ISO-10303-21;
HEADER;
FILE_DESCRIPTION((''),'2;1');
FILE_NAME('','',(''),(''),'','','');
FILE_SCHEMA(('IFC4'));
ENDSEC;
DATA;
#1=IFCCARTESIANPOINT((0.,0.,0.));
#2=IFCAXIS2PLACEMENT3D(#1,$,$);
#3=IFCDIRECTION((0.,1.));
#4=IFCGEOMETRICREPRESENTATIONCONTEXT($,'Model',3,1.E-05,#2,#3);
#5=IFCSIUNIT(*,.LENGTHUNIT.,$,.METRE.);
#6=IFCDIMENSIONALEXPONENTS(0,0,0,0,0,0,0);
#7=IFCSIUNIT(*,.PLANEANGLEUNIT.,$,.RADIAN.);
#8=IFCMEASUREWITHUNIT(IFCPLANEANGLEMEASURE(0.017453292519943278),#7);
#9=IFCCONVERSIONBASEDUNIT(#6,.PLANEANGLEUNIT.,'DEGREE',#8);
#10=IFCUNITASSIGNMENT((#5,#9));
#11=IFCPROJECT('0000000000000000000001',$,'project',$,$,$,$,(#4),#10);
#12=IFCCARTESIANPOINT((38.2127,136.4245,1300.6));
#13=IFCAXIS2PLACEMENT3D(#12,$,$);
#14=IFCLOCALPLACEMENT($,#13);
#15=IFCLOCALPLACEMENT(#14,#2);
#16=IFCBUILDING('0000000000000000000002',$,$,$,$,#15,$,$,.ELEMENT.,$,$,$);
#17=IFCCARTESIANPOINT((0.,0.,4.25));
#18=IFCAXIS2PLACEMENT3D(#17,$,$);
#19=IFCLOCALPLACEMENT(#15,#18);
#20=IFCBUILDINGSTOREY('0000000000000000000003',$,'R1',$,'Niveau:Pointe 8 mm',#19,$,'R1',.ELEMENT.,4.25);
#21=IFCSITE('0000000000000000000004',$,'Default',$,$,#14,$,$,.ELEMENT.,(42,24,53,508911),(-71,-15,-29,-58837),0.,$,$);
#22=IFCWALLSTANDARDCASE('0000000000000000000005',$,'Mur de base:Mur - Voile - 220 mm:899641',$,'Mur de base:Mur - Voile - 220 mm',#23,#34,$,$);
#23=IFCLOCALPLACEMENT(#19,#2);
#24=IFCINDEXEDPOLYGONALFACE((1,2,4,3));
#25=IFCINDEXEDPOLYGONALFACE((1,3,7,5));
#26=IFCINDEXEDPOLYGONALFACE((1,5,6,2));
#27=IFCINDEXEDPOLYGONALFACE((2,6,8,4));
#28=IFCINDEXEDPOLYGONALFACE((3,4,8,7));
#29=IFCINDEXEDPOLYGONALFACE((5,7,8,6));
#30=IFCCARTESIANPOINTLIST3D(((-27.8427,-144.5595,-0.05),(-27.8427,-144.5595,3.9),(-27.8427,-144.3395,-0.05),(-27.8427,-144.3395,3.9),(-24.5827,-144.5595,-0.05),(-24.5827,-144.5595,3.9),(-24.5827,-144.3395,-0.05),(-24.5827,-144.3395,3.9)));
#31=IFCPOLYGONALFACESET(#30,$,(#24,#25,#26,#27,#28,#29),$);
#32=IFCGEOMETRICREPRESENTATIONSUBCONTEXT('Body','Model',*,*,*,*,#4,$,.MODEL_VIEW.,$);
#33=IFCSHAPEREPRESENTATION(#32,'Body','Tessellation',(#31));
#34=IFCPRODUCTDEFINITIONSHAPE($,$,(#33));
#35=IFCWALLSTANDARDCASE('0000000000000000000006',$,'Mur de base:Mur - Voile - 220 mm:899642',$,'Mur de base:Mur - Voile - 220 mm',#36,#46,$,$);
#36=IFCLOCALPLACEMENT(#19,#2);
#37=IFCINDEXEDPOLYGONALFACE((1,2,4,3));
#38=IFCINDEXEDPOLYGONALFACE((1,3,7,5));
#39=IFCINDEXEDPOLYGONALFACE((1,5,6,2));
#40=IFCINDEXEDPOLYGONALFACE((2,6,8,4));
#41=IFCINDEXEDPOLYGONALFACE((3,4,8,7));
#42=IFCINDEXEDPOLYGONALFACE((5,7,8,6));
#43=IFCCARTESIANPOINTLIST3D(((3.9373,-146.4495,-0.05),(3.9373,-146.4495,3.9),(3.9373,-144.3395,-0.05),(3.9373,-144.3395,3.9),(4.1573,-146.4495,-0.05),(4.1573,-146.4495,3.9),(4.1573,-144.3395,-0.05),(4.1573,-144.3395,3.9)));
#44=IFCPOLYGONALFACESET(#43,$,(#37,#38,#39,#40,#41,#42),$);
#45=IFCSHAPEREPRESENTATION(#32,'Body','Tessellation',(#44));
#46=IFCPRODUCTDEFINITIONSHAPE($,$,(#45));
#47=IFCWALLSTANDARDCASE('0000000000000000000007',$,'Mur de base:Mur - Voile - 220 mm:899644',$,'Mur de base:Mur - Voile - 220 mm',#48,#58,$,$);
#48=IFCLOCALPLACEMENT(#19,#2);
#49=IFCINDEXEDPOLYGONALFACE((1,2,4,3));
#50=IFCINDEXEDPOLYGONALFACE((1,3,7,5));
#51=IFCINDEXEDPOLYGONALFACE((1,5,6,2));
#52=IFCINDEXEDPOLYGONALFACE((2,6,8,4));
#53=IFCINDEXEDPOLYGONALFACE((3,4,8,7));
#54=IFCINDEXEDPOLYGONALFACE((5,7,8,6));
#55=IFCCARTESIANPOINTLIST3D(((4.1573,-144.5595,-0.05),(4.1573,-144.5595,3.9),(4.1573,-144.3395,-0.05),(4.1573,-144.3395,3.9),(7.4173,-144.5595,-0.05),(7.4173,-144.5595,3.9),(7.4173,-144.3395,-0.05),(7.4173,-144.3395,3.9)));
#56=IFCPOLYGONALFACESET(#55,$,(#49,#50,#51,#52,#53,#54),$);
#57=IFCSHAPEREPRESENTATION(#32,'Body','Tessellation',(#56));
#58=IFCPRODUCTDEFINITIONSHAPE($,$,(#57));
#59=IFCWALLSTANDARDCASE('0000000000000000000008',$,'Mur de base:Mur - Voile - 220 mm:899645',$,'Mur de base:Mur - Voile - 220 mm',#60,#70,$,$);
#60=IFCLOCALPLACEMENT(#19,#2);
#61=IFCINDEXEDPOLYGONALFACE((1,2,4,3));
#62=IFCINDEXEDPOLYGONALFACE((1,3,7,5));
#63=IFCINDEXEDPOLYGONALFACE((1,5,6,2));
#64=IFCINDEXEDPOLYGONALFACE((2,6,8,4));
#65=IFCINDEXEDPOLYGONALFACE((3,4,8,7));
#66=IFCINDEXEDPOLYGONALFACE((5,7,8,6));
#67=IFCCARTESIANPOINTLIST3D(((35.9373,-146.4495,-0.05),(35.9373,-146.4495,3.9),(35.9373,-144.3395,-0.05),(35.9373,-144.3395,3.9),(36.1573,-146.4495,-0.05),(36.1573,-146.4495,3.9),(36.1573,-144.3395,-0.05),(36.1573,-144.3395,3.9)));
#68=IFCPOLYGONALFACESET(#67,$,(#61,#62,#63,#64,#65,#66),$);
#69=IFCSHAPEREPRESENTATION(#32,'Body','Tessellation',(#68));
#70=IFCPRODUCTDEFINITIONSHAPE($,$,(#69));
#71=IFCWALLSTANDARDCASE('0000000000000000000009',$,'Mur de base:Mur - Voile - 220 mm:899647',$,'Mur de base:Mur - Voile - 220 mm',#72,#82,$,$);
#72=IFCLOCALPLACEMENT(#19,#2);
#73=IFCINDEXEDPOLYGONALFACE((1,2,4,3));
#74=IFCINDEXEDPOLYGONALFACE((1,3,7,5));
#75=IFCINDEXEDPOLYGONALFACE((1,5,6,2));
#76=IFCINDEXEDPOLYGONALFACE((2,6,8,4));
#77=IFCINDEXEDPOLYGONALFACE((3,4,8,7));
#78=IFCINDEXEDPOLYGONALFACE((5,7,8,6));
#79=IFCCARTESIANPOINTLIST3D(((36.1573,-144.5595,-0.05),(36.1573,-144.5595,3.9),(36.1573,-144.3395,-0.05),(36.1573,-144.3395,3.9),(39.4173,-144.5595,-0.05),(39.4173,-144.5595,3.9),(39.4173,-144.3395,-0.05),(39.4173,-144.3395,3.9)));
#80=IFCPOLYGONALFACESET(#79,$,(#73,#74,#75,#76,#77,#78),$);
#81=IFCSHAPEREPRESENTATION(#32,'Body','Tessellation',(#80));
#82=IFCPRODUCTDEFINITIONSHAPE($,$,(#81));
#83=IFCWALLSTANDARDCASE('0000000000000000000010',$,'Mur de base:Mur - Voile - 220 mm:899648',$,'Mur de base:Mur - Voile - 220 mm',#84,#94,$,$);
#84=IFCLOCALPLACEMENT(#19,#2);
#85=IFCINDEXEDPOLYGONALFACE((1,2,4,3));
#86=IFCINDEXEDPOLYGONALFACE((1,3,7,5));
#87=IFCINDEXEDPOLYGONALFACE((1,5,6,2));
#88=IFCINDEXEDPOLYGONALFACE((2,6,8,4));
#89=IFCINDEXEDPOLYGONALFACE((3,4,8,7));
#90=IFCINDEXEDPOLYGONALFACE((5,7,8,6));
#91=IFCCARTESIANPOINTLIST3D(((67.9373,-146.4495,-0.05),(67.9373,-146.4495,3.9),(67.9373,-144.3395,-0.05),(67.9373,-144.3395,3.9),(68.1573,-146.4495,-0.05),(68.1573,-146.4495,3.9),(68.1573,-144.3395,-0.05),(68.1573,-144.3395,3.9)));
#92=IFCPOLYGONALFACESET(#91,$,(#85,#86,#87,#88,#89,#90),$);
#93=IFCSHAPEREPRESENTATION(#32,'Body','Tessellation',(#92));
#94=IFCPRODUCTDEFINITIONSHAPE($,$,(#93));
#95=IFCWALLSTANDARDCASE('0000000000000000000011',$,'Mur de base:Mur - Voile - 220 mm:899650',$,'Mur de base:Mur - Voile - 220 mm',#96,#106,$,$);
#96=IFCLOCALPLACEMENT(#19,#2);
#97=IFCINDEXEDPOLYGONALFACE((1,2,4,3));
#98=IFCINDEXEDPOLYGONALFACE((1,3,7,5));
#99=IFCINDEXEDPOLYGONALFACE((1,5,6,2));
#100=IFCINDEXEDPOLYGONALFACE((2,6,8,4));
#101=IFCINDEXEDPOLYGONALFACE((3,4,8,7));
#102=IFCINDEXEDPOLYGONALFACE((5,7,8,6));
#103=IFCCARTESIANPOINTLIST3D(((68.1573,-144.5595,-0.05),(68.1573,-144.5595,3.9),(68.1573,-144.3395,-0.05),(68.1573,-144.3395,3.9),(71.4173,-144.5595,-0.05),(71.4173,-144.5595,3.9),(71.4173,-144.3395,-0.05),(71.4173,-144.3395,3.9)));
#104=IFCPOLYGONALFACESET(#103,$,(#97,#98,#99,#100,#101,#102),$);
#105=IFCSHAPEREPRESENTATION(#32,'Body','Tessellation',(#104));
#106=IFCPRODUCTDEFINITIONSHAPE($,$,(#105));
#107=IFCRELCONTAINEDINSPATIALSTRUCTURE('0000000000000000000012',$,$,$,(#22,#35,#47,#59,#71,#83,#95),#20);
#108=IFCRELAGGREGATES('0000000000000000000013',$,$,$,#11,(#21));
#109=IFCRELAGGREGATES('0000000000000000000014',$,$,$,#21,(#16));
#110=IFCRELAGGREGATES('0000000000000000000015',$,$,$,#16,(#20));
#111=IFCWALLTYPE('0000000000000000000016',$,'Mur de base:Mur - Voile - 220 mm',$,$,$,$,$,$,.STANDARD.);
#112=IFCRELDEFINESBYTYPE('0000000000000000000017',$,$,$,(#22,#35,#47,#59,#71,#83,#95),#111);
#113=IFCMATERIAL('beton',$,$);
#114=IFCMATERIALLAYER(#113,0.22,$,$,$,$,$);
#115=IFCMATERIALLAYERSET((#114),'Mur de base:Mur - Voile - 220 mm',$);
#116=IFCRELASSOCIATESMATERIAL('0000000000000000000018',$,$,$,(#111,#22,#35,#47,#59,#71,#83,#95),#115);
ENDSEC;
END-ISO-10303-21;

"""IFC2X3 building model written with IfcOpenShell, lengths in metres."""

from ifc_helpers import new_model, entity, si_unit, converted_unit, direction, frame, frame_2d, origin, place, context, subcontext, project, spatial, polyline, rectangle, extrude, clip, bounded_halfspace, material, layer, layer_set, layer_usage, type_object, element, save


model = new_model("IFC2X3")

# Units and contexts
model_context = context("Model", 3, precision=1e-05, world=origin(), true_north=direction((0.0, 1.0)))
body_context = subcontext(model_context, "Body", "Model", "MODEL_VIEW")
ifc_project = project(units=[si_unit("LENGTHUNIT", "METRE"), converted_unit("PLANEANGLEUNIT", "DEGREE", entity("IfcPlaneAngleMeasure", 0.017453292519943278), si_unit("PLANEANGLEUNIT", "RADIAN"), dimensions=[0, 0, 0, 0, 0, 0, 0])], contexts=[model_context])

# Site, building, storey
site_placement = place(None, frame((38.2127, 136.4245, 1300.6)))
site = spatial("IfcSite", under=ifc_project, at=site_placement, Name="Default", CompositionType="ELEMENT", RefLatitude=(42, 24, 53, 508911), RefLongitude=(-71, -15, -29, -58837), RefElevation=0.0)
building_placement = place(site_placement, origin())
building = spatial("IfcBuilding", under=site, at=building_placement, CompositionType="ELEMENT")
storey_placement = place(building_placement, frame((0.0, 0.0, 4.25)))
storey = spatial("IfcBuildingStorey", under=building, at=storey_placement, Name="R1", ObjectType="Niveau:Pointe 8 mm", LongName="R1", CompositionType="ELEMENT", Elevation=4.25)

# Walls
ifc_material_1 = material(Name="beton")
ifc_layer_1 = layer(ifc_material_1, 0.22)
ifc_layer_set_1 = layer_set([ifc_layer_1], Name="Mur de base:Mur - Voile - 220 mm")
wall_type = type_object("IfcWallType", Name="Mur de base:Mur - Voile - 220 mm", PredefinedType="STANDARD", material=ifc_layer_set_1)
ifc_layer_usage_1 = layer_usage(ifc_layer_set_1, "AXIS2", "NEGATIVE", 0.11)
wall_1_placement = place(storey_placement, frame((-24.5827, -144.4495, -0.05), z_axis=(0.0, 0.0, 1.0), x_axis=(-1.0, 0.0, 0.0)))
element("IfcWallStandardCase", 1, at=wall_1_placement, inside=storey, type_object=wall_type, material=ifc_layer_usage_1, Name="Mur de base:Mur - Voile - 220 mm:899641", ObjectType="Mur de base:Mur - Voile - 220 mm", context=body_context, shape_type="Clipping", body=[
    clip(extrude(rectangle(XDim=3.26, YDim=0.22, at=frame_2d((1.63, 0.0), x_axis=(-1.0, 0.0))), origin(), (0.0, 0.0, 1.0), 3.95), bounded_halfspace(frame((0.0, -0.11, 3.95), z_axis=(0.0, 0.0, -1.0), x_axis=(-1.0, 0.0, 0.0)), True, frame((0.0, -0.11, 3.95)), polyline([(0.0, 0.0), (3.26, 0.0), (3.26, 0.22), (3.255, 0.22), (0.0, 0.22), (0.0, 0.0)]))),
])
ifc_layer_usage_2 = layer_usage(ifc_layer_set_1, "AXIS2", "NEGATIVE", 0.11)
wall_2_placement = place(storey_placement, frame((4.0473, -144.3395, -0.05), z_axis=(0.0, 0.0, 1.0), x_axis=(0.0, -1.0, 0.0)))
element("IfcWallStandardCase", 2, at=wall_2_placement, inside=storey, type_object=wall_type, material=ifc_layer_usage_2, Name="Mur de base:Mur - Voile - 220 mm:899642", ObjectType="Mur de base:Mur - Voile - 220 mm", context=body_context, shape_type="Clipping", body=[
    clip(extrude(rectangle(XDim=2.11, YDim=0.22, at=frame_2d((1.055, 0.0), x_axis=(-1.0, 0.0))), origin(), (0.0, 0.0, 1.0), 3.95), bounded_halfspace(frame((0.0, -0.11, 3.95), z_axis=(0.0, 0.0, -1.0), x_axis=(0.0, 1.0, 0.0)), True, frame((0.0, -0.11, 3.95)), polyline([(0.0, 0.0), (1.94, 0.0), (2.11, 0.0), (2.11, 0.22), (1.94, 0.22), (0.22, 0.22), (0.0, 0.22), (0.0, 0.0)]))),
])
ifc_layer_usage_3 = layer_usage(ifc_layer_set_1, "AXIS2", "NEGATIVE", 0.11)
wall_3_placement = place(storey_placement, frame((7.4173, -144.4495, -0.05), z_axis=(0.0, 0.0, 1.0), x_axis=(-1.0, 0.0, 0.0)))
element("IfcWallStandardCase", 3, at=wall_3_placement, inside=storey, type_object=wall_type, material=ifc_layer_usage_3, Name="Mur de base:Mur - Voile - 220 mm:899644", ObjectType="Mur de base:Mur - Voile - 220 mm", context=body_context, shape_type="Clipping", body=[
    clip(extrude(rectangle(XDim=3.26, YDim=0.22, at=frame_2d((1.63, 0.0), x_axis=(-1.0, 0.0))), origin(), (0.0, 0.0, 1.0), 3.95), bounded_halfspace(frame((0.0, -0.11, 3.95), z_axis=(0.0, 0.0, -1.0), x_axis=(-1.0, 0.0, 0.0)), True, frame((0.0, -0.11, 3.95)), polyline([(0.0, 0.0), (3.26, 0.0), (3.26, 0.22), (3.255, 0.22), (0.0, 0.22), (0.0, 0.0)]))),
])
ifc_layer_usage_4 = layer_usage(ifc_layer_set_1, "AXIS2", "NEGATIVE", 0.11)
wall_4_placement = place(storey_placement, frame((36.0473, -144.3395, -0.05), z_axis=(0.0, 0.0, 1.0), x_axis=(0.0, -1.0, 0.0)))
element("IfcWallStandardCase", 4, at=wall_4_placement, inside=storey, type_object=wall_type, material=ifc_layer_usage_4, Name="Mur de base:Mur - Voile - 220 mm:899645", ObjectType="Mur de base:Mur - Voile - 220 mm", context=body_context, shape_type="Clipping", body=[
    clip(extrude(rectangle(XDim=2.11, YDim=0.22, at=frame_2d((1.055, 0.0), x_axis=(-1.0, 0.0))), origin(), (0.0, 0.0, 1.0), 3.95), bounded_halfspace(frame((0.0, -0.11, 3.95), z_axis=(0.0, 0.0, -1.0), x_axis=(0.0, 1.0, 0.0)), True, frame((0.0, -0.11, 3.95)), polyline([(0.0, 0.0), (1.94, 0.0), (2.11, 0.0), (2.11, 0.22), (1.94, 0.22), (0.22, 0.22), (0.0, 0.22), (0.0, 0.0)]))),
])
ifc_layer_usage_5 = layer_usage(ifc_layer_set_1, "AXIS2", "NEGATIVE", 0.11)
wall_5_placement = place(storey_placement, frame((39.4173, -144.4495, -0.05), z_axis=(0.0, 0.0, 1.0), x_axis=(-1.0, 0.0, 0.0)))
element("IfcWallStandardCase", 5, at=wall_5_placement, inside=storey, type_object=wall_type, material=ifc_layer_usage_5, Name="Mur de base:Mur - Voile - 220 mm:899647", ObjectType="Mur de base:Mur - Voile - 220 mm", context=body_context, shape_type="Clipping", body=[
    clip(extrude(rectangle(XDim=3.26, YDim=0.22, at=frame_2d((1.63, 0.0), x_axis=(-1.0, 0.0))), origin(), (0.0, 0.0, 1.0), 3.95), bounded_halfspace(frame((0.0, -0.11, 3.95), z_axis=(0.0, 0.0, -1.0), x_axis=(-1.0, 0.0, 0.0)), True, frame((0.0, -0.11, 3.95)), polyline([(0.0, 0.0), (3.26, 0.0), (3.26, 0.22), (3.255, 0.22), (0.0, 0.22), (0.0, 0.0)]))),
])
ifc_layer_usage_6 = layer_usage(ifc_layer_set_1, "AXIS2", "NEGATIVE", 0.11)
wall_6_placement = place(storey_placement, frame((68.0473, -144.3395, -0.05), z_axis=(0.0, 0.0, 1.0), x_axis=(0.0, -1.0, 0.0)))
element("IfcWallStandardCase", 6, at=wall_6_placement, inside=storey, type_object=wall_type, material=ifc_layer_usage_6, Name="Mur de base:Mur - Voile - 220 mm:899648", ObjectType="Mur de base:Mur - Voile - 220 mm", context=body_context, shape_type="Clipping", body=[
    clip(extrude(rectangle(XDim=2.11, YDim=0.22, at=frame_2d((1.055, 0.0), x_axis=(-1.0, 0.0))), origin(), (0.0, 0.0, 1.0), 3.95), bounded_halfspace(frame((0.0, -0.11, 3.95), z_axis=(0.0, 0.0, -1.0), x_axis=(0.0, 1.0, 0.0)), True, frame((0.0, -0.11, 3.95)), polyline([(0.0, 0.0), (1.94, 0.0), (2.11, 0.0), (2.11, 0.22), (1.94, 0.22), (0.22, 0.22), (0.0, 0.22), (0.0, 0.0)]))),
])
ifc_layer_usage_7 = layer_usage(ifc_layer_set_1, "AXIS2", "NEGATIVE", 0.11)
wall_7_placement = place(storey_placement, frame((71.4173, -144.4495, -0.05), z_axis=(0.0, 0.0, 1.0), x_axis=(-1.0, 0.0, 0.0)))
element("IfcWallStandardCase", 7, at=wall_7_placement, inside=storey, type_object=wall_type, material=ifc_layer_usage_7, Name="Mur de base:Mur - Voile - 220 mm:899650", ObjectType="Mur de base:Mur - Voile - 220 mm", context=body_context, shape_type="Clipping", body=[
    clip(extrude(rectangle(XDim=3.26, YDim=0.22, at=frame_2d((1.63, 0.0), x_axis=(-1.0, 0.0))), origin(), (0.0, 0.0, 1.0), 3.95), bounded_halfspace(frame((0.0, -0.11, 3.95), z_axis=(0.0, 0.0, -1.0), x_axis=(-1.0, 0.0, 0.0)), True, frame((0.0, -0.11, 3.95)), polyline([(0.0, 0.0), (3.26, 0.0), (3.26, 0.22), (3.255, 0.22), (0.0, 0.22), (0.0, 0.0)]))),
])

save(model, "model.ifc")
